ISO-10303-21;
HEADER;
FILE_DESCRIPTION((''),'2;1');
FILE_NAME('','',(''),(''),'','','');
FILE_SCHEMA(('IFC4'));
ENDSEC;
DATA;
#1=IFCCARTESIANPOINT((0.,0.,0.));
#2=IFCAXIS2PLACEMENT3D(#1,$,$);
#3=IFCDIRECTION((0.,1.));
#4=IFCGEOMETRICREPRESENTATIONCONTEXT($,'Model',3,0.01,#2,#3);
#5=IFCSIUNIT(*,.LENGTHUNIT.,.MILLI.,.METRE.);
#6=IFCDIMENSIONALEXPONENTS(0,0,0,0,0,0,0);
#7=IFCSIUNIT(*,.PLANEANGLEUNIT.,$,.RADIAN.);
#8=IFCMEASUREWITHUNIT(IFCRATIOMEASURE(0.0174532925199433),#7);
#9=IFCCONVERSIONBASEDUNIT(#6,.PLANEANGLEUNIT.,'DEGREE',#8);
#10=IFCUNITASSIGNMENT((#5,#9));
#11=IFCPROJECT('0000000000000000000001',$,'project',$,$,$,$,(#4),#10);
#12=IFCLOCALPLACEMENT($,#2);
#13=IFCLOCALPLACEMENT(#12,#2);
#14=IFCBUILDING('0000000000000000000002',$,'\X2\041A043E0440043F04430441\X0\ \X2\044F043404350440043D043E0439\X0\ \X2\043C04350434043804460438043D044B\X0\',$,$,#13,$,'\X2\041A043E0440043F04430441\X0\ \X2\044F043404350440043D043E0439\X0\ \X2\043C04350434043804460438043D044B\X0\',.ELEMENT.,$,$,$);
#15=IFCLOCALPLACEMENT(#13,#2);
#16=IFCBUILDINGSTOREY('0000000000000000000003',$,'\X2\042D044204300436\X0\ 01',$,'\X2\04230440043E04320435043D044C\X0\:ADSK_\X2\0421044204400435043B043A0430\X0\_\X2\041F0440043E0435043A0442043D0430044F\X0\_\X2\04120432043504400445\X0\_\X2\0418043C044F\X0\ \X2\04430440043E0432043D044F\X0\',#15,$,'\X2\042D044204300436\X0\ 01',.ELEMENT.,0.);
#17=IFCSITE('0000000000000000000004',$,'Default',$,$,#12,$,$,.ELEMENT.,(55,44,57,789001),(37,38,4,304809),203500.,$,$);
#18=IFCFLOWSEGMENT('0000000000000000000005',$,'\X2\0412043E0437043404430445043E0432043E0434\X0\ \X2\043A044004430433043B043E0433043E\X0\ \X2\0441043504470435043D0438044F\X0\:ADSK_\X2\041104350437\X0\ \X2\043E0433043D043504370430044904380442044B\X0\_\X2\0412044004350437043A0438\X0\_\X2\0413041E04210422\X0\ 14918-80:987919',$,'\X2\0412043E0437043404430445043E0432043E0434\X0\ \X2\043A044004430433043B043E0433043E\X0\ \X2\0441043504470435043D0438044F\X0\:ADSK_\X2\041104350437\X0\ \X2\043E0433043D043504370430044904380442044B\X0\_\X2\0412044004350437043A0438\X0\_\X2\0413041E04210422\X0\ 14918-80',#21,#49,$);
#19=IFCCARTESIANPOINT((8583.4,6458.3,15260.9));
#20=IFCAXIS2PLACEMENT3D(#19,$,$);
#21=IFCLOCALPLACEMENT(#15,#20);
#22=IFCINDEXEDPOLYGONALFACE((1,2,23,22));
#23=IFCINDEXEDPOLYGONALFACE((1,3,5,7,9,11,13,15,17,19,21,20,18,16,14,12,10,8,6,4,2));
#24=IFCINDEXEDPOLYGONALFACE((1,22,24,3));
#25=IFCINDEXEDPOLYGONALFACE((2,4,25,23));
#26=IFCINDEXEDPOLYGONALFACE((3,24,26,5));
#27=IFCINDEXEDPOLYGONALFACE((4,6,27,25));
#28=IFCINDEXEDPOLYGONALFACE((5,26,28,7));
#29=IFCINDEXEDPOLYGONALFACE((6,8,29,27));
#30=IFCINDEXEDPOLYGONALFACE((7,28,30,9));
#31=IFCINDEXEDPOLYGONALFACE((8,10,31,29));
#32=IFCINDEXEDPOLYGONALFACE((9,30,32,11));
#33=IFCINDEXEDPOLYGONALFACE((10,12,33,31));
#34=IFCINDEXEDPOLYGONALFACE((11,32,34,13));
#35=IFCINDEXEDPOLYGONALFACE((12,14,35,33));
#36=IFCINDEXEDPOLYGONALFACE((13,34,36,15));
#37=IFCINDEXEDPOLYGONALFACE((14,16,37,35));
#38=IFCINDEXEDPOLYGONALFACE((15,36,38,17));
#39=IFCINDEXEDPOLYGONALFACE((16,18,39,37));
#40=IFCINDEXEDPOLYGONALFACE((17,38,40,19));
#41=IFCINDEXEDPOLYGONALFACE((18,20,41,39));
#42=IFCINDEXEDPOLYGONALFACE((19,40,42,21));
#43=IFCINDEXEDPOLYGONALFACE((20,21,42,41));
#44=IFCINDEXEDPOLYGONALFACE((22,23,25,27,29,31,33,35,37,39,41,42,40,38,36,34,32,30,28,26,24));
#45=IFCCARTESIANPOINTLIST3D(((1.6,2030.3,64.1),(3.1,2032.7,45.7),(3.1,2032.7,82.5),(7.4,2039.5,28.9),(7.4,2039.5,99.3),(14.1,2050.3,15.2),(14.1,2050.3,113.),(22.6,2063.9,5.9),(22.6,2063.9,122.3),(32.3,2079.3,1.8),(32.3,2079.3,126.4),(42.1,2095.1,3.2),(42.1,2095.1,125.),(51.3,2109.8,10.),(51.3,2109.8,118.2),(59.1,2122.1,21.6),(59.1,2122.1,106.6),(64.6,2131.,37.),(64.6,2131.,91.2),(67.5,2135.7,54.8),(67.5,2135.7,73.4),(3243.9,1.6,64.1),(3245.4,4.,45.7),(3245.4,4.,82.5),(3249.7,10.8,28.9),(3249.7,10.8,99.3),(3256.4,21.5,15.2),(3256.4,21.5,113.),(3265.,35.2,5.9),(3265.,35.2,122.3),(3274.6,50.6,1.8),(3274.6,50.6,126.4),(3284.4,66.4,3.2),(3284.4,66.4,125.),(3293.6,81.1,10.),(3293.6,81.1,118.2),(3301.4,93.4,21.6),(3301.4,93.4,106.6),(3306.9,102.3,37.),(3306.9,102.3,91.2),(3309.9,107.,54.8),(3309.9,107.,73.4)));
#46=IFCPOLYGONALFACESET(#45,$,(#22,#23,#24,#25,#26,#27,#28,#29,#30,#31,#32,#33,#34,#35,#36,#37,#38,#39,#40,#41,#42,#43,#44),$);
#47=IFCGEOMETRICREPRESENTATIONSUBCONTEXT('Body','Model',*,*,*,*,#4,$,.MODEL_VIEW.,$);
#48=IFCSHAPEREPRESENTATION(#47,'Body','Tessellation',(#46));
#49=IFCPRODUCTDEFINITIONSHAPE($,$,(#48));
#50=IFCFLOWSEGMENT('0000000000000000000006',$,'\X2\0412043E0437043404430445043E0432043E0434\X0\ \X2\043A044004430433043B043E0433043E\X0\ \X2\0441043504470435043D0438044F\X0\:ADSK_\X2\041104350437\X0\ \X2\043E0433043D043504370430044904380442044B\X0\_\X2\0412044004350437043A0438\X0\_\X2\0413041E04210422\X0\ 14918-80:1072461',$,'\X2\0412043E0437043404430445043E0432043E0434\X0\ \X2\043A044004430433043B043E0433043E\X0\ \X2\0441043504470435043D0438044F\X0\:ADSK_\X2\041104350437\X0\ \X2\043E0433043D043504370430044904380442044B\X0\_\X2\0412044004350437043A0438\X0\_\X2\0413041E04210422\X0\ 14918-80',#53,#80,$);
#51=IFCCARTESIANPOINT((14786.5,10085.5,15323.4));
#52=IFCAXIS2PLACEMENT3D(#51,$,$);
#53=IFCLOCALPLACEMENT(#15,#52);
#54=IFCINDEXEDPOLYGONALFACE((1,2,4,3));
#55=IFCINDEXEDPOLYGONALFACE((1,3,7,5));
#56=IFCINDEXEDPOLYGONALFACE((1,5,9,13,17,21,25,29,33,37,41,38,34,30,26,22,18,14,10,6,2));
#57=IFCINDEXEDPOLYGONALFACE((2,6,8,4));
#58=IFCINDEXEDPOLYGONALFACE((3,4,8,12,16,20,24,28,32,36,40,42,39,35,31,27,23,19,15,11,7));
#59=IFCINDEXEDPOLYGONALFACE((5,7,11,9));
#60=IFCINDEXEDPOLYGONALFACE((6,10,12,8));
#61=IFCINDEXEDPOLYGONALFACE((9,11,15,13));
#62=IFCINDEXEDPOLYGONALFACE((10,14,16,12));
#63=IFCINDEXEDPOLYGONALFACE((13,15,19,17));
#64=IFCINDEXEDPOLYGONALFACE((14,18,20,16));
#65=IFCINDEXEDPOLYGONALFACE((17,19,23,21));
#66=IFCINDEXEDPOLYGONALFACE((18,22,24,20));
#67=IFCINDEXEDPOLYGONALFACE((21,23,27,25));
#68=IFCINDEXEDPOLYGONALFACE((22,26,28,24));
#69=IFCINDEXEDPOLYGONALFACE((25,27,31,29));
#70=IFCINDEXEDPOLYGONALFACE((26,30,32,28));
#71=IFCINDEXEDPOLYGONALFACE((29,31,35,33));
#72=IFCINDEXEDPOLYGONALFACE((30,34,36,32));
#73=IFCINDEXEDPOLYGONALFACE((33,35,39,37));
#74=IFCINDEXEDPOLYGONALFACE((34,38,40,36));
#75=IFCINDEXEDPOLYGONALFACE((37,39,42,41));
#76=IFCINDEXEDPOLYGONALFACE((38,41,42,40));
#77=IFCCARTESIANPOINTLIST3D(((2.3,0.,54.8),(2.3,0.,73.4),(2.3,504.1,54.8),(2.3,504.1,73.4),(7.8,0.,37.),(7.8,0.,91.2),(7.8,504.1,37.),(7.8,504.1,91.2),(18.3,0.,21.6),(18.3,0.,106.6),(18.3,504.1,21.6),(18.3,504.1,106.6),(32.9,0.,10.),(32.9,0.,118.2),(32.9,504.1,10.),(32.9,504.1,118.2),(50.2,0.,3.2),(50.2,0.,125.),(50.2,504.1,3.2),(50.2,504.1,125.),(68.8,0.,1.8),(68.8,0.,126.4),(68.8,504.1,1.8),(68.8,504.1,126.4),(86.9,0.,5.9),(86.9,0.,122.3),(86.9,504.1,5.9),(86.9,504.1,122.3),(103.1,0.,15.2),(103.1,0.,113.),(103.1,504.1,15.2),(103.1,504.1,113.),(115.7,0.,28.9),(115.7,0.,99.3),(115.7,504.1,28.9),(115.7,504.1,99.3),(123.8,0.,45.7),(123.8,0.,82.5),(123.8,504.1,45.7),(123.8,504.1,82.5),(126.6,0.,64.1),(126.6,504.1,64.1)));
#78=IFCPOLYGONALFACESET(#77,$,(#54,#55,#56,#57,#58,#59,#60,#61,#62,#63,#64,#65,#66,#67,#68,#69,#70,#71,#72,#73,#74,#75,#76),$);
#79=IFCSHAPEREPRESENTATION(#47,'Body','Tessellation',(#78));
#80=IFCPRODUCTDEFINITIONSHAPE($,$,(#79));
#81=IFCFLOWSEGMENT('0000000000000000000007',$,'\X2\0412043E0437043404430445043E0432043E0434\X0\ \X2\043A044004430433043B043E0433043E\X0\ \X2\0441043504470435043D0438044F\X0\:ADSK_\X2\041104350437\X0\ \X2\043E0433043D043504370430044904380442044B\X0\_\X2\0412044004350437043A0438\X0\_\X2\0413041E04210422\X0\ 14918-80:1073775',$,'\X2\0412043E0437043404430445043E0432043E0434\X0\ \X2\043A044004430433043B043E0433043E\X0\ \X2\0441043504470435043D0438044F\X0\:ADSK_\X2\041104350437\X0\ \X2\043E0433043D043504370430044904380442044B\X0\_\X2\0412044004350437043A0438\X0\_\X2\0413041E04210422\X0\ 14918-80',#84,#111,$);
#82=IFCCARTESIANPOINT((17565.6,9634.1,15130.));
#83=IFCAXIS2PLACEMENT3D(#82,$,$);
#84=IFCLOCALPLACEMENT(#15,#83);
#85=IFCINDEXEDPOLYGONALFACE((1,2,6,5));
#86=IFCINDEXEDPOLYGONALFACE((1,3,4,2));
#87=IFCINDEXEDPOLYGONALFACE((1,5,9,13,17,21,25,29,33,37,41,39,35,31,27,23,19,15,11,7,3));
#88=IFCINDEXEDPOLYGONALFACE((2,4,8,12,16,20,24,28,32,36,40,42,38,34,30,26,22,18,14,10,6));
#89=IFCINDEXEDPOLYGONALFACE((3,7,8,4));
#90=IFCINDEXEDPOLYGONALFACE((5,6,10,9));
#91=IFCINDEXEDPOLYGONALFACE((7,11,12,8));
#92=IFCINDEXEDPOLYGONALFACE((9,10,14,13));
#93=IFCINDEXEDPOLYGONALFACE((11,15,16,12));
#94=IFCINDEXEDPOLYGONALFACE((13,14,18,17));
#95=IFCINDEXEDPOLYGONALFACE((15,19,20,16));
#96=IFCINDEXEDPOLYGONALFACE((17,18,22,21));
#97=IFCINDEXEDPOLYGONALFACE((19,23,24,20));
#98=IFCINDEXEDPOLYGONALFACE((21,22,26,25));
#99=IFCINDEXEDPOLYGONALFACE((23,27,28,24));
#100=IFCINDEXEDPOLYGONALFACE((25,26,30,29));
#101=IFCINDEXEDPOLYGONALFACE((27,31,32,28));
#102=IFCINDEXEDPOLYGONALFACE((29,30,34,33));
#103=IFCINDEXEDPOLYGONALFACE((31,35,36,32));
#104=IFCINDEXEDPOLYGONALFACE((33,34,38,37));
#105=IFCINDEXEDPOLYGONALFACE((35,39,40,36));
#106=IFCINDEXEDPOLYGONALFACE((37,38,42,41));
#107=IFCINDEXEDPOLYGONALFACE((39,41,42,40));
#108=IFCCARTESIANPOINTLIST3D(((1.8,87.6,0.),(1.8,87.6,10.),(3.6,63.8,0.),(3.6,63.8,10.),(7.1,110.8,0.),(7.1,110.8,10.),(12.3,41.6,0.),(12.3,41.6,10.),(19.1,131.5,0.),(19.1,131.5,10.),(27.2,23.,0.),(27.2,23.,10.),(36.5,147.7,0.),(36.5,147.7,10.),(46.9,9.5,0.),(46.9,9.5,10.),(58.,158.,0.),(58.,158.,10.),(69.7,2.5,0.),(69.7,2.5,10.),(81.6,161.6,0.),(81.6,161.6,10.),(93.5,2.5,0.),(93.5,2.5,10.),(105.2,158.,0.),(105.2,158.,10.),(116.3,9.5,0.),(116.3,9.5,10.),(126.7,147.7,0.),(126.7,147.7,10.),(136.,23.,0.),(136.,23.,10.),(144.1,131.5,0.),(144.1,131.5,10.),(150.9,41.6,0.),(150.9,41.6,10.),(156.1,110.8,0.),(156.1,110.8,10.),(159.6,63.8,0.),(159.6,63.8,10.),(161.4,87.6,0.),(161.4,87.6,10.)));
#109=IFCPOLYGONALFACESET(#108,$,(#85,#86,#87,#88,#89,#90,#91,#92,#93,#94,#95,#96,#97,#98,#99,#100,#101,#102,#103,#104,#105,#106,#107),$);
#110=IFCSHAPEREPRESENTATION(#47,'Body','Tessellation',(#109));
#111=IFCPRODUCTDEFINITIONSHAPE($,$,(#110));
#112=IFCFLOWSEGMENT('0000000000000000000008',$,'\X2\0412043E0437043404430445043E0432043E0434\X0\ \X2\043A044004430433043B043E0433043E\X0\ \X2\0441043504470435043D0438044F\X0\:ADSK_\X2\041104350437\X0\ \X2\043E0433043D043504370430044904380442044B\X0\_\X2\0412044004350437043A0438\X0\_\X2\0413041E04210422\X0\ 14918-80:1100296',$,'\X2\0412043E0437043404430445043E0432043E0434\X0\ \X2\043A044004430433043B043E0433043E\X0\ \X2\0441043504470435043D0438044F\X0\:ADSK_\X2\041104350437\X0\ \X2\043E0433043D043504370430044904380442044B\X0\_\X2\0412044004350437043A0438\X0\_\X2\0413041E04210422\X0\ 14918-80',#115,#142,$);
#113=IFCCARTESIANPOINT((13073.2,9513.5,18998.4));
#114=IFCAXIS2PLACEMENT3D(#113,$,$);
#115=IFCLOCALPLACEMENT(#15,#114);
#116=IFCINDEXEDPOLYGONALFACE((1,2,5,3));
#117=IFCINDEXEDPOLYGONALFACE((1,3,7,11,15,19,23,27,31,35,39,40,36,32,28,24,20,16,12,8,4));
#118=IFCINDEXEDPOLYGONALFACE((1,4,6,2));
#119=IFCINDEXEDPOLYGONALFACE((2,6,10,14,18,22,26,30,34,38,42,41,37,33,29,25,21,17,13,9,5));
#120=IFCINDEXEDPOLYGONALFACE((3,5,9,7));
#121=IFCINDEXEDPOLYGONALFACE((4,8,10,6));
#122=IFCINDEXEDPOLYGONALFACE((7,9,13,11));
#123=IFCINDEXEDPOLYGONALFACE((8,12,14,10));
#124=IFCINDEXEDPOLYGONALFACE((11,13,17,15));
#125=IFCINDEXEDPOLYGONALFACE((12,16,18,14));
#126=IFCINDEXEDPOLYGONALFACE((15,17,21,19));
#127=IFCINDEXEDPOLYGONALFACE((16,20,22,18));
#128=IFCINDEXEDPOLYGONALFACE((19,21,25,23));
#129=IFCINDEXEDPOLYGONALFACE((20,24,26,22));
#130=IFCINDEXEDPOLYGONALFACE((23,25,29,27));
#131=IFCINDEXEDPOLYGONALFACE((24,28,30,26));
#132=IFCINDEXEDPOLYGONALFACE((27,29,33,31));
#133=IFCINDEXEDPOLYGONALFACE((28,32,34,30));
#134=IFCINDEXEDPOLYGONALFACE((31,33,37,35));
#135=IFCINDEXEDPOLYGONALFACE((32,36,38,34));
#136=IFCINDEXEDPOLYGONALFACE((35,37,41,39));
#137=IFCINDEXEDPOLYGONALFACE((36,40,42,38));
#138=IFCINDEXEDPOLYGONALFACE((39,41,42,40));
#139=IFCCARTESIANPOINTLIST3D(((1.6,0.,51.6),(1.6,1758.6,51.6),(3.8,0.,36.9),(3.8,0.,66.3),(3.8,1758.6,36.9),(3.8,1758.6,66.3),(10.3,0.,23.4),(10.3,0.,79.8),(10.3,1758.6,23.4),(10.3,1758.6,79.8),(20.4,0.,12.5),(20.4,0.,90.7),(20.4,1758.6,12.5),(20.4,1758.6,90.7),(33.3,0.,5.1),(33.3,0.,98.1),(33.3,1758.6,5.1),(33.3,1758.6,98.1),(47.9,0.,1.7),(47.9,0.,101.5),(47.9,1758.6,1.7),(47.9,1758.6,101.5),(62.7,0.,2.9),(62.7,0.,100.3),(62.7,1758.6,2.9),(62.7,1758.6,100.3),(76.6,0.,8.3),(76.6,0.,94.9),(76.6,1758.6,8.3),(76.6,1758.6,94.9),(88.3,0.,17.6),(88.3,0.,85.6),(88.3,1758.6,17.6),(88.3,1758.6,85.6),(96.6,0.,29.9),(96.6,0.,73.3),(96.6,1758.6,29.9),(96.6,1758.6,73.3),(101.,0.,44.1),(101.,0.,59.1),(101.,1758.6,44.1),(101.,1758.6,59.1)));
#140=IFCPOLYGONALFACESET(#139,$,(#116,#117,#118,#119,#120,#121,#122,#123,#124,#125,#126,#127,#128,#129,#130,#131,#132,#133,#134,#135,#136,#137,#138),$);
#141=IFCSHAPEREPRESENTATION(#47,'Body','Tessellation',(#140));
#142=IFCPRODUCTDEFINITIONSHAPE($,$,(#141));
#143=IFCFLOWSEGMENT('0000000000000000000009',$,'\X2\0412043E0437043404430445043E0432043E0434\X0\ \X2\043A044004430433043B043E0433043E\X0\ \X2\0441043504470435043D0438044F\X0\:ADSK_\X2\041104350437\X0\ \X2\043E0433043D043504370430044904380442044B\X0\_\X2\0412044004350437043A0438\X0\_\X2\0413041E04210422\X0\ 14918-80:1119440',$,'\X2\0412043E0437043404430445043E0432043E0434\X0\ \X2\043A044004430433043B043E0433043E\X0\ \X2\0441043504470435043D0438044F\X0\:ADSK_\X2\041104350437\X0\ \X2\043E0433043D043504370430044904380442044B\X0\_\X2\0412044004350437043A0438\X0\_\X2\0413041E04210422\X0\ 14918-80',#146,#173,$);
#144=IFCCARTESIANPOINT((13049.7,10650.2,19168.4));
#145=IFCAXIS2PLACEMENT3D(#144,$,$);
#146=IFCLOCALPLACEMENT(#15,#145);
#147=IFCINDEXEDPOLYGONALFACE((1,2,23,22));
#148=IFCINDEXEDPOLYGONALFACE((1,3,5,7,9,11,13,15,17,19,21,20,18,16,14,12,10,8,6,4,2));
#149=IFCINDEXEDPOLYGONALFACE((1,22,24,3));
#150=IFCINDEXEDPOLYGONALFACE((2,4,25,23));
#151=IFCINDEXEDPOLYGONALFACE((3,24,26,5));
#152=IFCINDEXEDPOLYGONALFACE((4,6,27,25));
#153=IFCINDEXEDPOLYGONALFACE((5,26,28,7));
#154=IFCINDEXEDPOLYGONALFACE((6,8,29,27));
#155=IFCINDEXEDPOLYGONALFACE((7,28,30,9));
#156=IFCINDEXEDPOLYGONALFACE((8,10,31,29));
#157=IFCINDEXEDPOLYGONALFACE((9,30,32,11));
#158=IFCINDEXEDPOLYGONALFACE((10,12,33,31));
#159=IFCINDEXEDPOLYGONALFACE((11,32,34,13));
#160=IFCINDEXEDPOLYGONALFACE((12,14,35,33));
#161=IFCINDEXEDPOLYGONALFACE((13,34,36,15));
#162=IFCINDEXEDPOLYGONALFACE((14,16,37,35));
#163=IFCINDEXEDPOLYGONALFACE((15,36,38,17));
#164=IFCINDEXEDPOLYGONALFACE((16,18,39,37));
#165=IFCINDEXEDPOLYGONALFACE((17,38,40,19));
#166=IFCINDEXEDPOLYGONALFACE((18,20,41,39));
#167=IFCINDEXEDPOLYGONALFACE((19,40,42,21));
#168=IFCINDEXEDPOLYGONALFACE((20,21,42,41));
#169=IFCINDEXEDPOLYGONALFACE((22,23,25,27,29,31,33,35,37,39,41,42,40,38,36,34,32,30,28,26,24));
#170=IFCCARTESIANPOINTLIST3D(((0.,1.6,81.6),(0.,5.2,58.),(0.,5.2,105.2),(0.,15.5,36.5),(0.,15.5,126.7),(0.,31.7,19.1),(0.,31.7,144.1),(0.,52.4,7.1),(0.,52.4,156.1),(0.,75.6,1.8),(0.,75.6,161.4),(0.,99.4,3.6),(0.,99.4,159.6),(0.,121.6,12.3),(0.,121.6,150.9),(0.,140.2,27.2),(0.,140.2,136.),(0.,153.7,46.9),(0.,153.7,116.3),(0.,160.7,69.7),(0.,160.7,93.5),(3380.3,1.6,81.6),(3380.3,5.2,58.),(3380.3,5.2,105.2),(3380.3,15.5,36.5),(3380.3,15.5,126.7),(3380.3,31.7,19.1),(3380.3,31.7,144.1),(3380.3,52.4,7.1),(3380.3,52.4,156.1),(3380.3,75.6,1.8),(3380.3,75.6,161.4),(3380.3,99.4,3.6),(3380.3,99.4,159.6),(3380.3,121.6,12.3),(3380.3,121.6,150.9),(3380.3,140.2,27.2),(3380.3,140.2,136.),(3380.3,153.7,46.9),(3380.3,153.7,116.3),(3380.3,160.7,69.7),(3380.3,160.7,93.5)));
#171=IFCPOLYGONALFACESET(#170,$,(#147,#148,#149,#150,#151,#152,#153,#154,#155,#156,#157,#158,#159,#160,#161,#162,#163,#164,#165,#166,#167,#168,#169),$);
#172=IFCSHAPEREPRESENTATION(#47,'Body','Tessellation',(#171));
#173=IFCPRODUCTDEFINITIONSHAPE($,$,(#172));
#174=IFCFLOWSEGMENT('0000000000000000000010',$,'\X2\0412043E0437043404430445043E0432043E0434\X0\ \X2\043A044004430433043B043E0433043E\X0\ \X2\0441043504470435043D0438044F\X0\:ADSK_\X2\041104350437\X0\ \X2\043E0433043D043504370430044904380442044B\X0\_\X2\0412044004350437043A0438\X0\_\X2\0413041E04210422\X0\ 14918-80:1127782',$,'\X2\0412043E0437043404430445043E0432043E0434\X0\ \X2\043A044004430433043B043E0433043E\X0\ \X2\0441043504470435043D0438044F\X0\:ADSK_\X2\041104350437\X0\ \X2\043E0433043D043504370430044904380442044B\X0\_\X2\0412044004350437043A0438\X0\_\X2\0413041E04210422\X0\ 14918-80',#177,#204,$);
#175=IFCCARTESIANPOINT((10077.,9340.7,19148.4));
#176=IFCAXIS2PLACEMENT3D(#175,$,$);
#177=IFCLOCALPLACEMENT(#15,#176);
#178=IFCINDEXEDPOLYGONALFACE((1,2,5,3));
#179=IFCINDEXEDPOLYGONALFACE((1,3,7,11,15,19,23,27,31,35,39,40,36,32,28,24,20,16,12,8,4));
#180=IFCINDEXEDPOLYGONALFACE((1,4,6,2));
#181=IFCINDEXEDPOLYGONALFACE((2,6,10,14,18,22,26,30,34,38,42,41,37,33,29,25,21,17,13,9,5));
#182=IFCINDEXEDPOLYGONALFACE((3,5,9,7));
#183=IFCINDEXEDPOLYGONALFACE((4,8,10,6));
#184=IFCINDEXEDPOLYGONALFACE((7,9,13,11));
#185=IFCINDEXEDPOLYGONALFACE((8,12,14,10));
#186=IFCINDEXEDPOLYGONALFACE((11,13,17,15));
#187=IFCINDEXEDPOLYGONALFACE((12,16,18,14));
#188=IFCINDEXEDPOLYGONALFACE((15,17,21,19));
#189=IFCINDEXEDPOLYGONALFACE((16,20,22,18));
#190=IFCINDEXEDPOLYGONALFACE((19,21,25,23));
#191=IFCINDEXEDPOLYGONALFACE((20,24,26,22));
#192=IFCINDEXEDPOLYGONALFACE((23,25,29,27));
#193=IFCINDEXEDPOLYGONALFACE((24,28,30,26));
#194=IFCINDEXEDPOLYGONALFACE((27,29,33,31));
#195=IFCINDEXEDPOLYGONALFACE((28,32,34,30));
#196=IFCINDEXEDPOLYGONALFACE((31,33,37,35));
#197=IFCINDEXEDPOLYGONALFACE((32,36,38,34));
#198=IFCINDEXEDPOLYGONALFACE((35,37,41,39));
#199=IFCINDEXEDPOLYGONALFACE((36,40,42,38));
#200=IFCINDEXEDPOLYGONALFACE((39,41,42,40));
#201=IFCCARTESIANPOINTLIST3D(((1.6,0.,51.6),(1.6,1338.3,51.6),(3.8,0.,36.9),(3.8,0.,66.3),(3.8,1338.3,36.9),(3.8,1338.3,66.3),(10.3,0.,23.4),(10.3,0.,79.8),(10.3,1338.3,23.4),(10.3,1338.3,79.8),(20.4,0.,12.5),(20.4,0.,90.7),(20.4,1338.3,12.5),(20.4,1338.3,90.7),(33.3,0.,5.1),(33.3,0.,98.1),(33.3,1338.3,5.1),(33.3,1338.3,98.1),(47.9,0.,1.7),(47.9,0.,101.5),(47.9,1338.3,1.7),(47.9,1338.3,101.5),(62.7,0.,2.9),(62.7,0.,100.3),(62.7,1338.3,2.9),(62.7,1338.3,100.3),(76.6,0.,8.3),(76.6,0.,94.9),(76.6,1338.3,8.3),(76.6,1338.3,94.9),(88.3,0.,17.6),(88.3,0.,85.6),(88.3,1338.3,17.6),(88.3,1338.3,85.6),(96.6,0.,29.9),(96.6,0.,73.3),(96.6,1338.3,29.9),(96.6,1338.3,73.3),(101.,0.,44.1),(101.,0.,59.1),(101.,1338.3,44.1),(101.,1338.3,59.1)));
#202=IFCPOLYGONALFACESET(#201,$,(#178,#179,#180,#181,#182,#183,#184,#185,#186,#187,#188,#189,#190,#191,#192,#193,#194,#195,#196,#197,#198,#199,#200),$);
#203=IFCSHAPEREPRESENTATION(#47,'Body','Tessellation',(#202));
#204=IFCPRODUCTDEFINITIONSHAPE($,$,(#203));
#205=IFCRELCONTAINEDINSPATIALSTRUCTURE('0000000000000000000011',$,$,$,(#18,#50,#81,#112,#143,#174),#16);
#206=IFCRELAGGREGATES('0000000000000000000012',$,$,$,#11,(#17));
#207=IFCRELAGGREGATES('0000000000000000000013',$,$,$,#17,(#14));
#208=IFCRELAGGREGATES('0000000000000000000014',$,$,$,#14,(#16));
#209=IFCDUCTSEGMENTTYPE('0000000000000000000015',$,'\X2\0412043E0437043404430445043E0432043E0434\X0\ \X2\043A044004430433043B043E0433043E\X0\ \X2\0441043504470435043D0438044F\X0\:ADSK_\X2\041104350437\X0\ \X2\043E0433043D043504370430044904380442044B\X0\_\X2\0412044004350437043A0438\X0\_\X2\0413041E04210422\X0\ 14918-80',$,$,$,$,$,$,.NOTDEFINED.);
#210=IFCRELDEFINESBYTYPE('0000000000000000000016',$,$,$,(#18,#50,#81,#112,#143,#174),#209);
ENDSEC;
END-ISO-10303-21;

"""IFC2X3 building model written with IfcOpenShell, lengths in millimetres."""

from ifc_helpers import new_model, entity, si_unit, converted_unit, direction, frame, origin, origin_2d_with_axis, place, context, subcontext, project, spatial, circle, extrude, type_object, element, save


model = new_model("IFC2X3")

# Units and contexts
model_context = context("Model", 3, precision=0.01, world=origin(), true_north=direction((0.0, 1.0)))
body_context = subcontext(model_context, "Body", "Model", "MODEL_VIEW")
ifc_project = project(units=[si_unit("LENGTHUNIT", "METRE", prefix="MILLI"), converted_unit("PLANEANGLEUNIT", "DEGREE", entity("IfcRatioMeasure", 0.0174532925199433), si_unit("PLANEANGLEUNIT", "RADIAN"), dimensions=[0, 0, 0, 0, 0, 0, 0])], contexts=[model_context])

# Site, building, storey
site_placement = place(None, origin())
site = spatial("IfcSite", under=ifc_project, at=site_placement, Name="Default", CompositionType="ELEMENT", RefLatitude=(55, 44, 57, 789001), RefLongitude=(37, 38, 4, 304809), RefElevation=203500.0)
building_placement = place(site_placement, origin())
building = spatial("IfcBuilding", under=site, at=building_placement, Name="Корпус ядерной медицины", LongName="Корпус ядерной медицины", CompositionType="ELEMENT")
storey_placement = place(building_placement, origin())
storey = spatial("IfcBuildingStorey", under=building, at=storey_placement, Name="Этаж 01", ObjectType="Уровень:ADSK_Стрелка_Проектная_Вверх_Имя уровня", LongName="Этаж 01", CompositionType="ELEMENT", Elevation=0.0)

# Flow segments
duct_segment_type_1 = type_object("IfcDuctSegmentType", Name="Воздуховод круглого сечения:ADSK_Без огнезащиты_Врезки_ГОСТ 14918-80", PredefinedType="NOTDEFINED")
flow_segment_1_placement = place(storey_placement, frame((8583.4, 6458.3, 15260.9)))
element("IfcFlowSegment", 1, at=flow_segment_1_placement, inside=storey, type_object=duct_segment_type_1, Name="Воздуховод круглого сечения:ADSK_Без огнезащиты_Врезки_ГОСТ 14918-80:987919", ObjectType="Воздуховод круглого сечения:ADSK_Без огнезащиты_Врезки_ГОСТ 14918-80", context=body_context, shape_type="SweptSolid", body=[
    extrude(circle(Radius=62.5, at=origin_2d_with_axis()), frame((34.8, 2083.3, 64.1), z_axis=(0.847732, -0.530425, 0.0), x_axis=(-0.530425, -0.847732, 0.0)), (0.0, 0.0, 1.0), 3824.7),
])
flow_segment_2_placement = place(storey_placement, frame((14786.5, 10085.5, 15323.4)))
element("IfcFlowSegment", 2, at=flow_segment_2_placement, inside=storey, type_object=duct_segment_type_1, Name="Воздуховод круглого сечения:ADSK_Без огнезащиты_Врезки_ГОСТ 14918-80:1072461", ObjectType="Воздуховод круглого сечения:ADSK_Без огнезащиты_Врезки_ГОСТ 14918-80", context=body_context, shape_type="SweptSolid", body=[
    extrude(circle(Radius=62.5, at=origin_2d_with_axis()), frame((64.1, 0.0, 64.1), z_axis=(0.0, 1.0, 0.0), x_axis=(1.0, 0.0, 0.0)), (0.0, 0.0, 1.0), 504.1),
])
flow_segment_3_placement = place(storey_placement, frame((17565.6, 9634.1, 15130.0)))
element("IfcFlowSegment", 3, at=flow_segment_3_placement, inside=storey, type_object=duct_segment_type_1, Name="Воздуховод круглого сечения:ADSK_Без огнезащиты_Врезки_ГОСТ 14918-80:1073775", ObjectType="Воздуховод круглого сечения:ADSK_Без огнезащиты_Врезки_ГОСТ 14918-80", context=body_context, shape_type="SweptSolid", body=[
    extrude(circle(Radius=80.0, at=origin_2d_with_axis()), frame((81.6, 81.6, 0.0), z_axis=(0.0, 0.0, 1.0), x_axis=(0.0, 1.0, 0.0)), (0.0, 0.0, 1.0), 10.0),
])
flow_segment_4_placement = place(storey_placement, frame((13073.2, 9513.5, 18998.4)))
element("IfcFlowSegment", 4, at=flow_segment_4_placement, inside=storey, type_object=duct_segment_type_1, Name="Воздуховод круглого сечения:ADSK_Без огнезащиты_Врезки_ГОСТ 14918-80:1100296", ObjectType="Воздуховод круглого сечения:ADSK_Без огнезащиты_Врезки_ГОСТ 14918-80", context=body_context, shape_type="SweptSolid", body=[
    extrude(circle(Radius=50.0, at=origin_2d_with_axis()), frame((51.6, 0.0, 51.6), z_axis=(0.0, 1.0, 0.0), x_axis=(-1.0, 0.0, 0.0)), (0.0, 0.0, 1.0), 1758.6),
])
flow_segment_5_placement = place(storey_placement, frame((13049.7, 10650.2, 19168.4)))
element("IfcFlowSegment", 5, at=flow_segment_5_placement, inside=storey, type_object=duct_segment_type_1, Name="Воздуховод круглого сечения:ADSK_Без огнезащиты_Врезки_ГОСТ 14918-80:1119440", ObjectType="Воздуховод круглого сечения:ADSK_Без огнезащиты_Врезки_ГОСТ 14918-80", context=body_context, shape_type="SweptSolid", body=[
    extrude(circle(Radius=80.0, at=origin_2d_with_axis()), frame((0.0, 81.6, 81.6), z_axis=(1.0, 0.0, 0.0), x_axis=(0.0, -1.0, 0.0)), (0.0, 0.0, 1.0), 3380.3),
])
flow_segment_6_placement = place(storey_placement, frame((10077.0, 9340.7, 19148.4)))
element("IfcFlowSegment", 6, at=flow_segment_6_placement, inside=storey, type_object=duct_segment_type_1, Name="Воздуховод круглого сечения:ADSK_Без огнезащиты_Врезки_ГОСТ 14918-80:1127782", ObjectType="Воздуховод круглого сечения:ADSK_Без огнезащиты_Врезки_ГОСТ 14918-80", context=body_context, shape_type="SweptSolid", body=[
    extrude(circle(Radius=50.0, at=origin_2d_with_axis()), frame((51.6, 0.0, 51.6), z_axis=(0.0, 1.0, 0.0), x_axis=(-1.0, 0.0, 0.0)), (0.0, 0.0, 1.0), 1338.3),
])

save(model, "model.ifc")
